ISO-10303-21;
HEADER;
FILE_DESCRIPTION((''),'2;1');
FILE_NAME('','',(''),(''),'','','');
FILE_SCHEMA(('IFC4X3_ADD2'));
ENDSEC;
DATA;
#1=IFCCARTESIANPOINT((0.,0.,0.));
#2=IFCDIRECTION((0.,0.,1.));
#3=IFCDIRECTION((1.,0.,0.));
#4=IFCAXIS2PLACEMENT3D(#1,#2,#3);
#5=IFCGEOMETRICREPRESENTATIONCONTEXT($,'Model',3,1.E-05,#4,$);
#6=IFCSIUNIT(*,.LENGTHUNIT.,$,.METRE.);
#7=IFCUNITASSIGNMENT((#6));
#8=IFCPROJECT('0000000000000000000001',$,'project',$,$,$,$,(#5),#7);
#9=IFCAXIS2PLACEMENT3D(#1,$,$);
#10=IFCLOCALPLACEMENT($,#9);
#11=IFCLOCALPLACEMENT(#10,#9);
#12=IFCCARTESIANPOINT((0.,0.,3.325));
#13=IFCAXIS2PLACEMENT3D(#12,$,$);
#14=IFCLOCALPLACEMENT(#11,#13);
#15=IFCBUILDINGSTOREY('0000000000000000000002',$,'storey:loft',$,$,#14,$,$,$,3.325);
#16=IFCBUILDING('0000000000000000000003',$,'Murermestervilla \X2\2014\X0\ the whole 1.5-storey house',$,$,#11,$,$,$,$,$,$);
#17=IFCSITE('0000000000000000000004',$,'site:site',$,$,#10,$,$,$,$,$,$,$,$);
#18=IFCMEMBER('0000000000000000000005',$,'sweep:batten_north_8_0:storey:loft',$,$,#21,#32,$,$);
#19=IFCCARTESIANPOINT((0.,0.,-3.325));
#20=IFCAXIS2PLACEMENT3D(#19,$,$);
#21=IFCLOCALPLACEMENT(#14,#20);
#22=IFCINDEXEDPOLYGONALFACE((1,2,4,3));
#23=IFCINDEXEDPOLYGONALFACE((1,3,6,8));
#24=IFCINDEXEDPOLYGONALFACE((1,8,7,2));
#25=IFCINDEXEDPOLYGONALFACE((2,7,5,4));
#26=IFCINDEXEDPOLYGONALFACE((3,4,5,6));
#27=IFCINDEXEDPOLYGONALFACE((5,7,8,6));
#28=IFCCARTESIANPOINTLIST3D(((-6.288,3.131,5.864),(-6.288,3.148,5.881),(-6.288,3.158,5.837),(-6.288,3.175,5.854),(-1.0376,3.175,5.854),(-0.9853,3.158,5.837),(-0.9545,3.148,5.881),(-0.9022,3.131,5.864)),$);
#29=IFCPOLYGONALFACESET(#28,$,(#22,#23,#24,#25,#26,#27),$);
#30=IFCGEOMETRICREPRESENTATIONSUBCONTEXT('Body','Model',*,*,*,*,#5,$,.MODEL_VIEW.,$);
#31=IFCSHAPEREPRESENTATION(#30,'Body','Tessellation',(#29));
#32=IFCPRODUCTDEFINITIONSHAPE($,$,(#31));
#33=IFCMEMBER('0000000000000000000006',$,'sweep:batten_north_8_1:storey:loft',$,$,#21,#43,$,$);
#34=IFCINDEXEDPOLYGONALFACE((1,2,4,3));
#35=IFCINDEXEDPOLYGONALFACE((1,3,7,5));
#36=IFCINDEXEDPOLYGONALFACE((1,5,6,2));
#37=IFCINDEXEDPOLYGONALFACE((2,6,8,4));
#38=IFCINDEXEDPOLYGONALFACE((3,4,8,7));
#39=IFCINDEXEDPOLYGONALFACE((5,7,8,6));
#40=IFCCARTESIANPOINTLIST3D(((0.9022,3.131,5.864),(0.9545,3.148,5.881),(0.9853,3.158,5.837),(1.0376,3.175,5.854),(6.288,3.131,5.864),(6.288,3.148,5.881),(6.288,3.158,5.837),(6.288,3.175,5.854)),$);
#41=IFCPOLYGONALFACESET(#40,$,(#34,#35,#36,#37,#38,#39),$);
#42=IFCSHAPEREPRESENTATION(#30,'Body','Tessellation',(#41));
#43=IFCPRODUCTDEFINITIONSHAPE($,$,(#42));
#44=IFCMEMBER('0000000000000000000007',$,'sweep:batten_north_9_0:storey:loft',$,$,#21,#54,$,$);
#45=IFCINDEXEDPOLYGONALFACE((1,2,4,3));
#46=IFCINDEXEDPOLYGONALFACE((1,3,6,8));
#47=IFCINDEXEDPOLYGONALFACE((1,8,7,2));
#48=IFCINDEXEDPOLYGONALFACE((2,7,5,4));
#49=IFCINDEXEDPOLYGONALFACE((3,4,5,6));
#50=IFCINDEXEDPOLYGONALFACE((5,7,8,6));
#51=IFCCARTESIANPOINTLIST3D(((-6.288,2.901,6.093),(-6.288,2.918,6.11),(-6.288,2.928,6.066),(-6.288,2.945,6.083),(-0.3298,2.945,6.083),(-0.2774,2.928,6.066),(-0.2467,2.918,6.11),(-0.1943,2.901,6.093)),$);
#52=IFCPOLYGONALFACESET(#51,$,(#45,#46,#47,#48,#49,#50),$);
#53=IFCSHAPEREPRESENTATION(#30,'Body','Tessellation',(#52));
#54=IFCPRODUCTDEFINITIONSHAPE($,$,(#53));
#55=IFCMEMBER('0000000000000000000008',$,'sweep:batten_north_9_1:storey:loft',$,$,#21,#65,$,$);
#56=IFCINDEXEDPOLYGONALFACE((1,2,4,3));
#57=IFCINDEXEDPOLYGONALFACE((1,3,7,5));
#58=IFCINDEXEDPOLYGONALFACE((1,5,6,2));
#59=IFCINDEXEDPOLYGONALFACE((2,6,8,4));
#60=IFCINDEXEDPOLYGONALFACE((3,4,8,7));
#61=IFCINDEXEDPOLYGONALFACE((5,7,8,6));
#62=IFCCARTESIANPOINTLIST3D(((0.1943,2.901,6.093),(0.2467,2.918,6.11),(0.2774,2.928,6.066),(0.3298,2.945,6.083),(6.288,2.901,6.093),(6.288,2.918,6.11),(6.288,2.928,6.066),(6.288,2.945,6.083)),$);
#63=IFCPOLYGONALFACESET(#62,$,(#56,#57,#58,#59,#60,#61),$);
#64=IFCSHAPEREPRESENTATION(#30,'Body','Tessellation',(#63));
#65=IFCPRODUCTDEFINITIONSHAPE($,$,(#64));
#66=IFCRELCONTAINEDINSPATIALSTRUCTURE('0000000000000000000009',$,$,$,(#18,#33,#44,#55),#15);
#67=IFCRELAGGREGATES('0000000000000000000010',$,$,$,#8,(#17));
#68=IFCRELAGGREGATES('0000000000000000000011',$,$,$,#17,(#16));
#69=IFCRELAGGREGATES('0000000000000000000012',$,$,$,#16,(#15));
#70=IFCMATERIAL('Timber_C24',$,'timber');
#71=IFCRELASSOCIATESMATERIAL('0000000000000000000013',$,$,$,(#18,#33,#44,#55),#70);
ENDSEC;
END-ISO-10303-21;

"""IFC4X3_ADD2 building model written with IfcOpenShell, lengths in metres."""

from ifc_helpers import new_model, si_unit, frame, origin, origin_with_axes, place, context, subcontext, project, spatial, polyline, outline, extrude, clip, halfspace, material, element, save


model = new_model("IFC4X3_ADD2")

# Units and contexts
model_context = context("Model", 3, precision=1e-05, world=origin_with_axes())
body_context = subcontext(model_context, "Body", "Model", "MODEL_VIEW")
ifc_project = project(units=[si_unit("LENGTHUNIT", "METRE")], contexts=[model_context])

# Site, building, storey
placement_1 = place(None, origin())
site = spatial("IfcSite", under=ifc_project, at=placement_1, Name="site:site")
building_placement = place(placement_1, origin())
building = spatial("IfcBuilding", under=site, at=building_placement, Name="Murermestervilla — the whole 1.5-storey house")
storey_placement = place(building_placement, frame((0.0, 0.0, 3.325)))
storey = spatial("IfcBuildingStorey", under=building, at=storey_placement, Name="storey:loft", Elevation=3.325)

# Members
ifc_material_1 = material(Name="Timber_C24", Category="timber")
placement_2 = place(storey_placement, frame((0.0, 0.0, -3.325)))
element("IfcMember", 1, at=placement_2, inside=storey, material=ifc_material_1, Name="sweep:batten_north_8_0:storey:loft", context=body_context, shape_type="CSG", body=[
    clip(extrude(outline(polyline([(0.022, -0.005), (-0.005, 0.022), (-0.022, 0.005), (0.005, -0.022), (0.022, -0.005)])), frame((-6.288, 3.153, 5.859), z_axis=(1.0, 0.0, 0.0), x_axis=(0.0, 1.0, 0.0)), (0.0, 0.0, 1.0), 5.564), halfspace(frame((-1.29, 3.257, 5.596), z_axis=(-0.309017, -0.951057, 0.0), x_axis=(-0.951057, 0.309017, 0.0)), True)),
])
element("IfcMember", 2, at=placement_2, inside=storey, material=ifc_material_1, Name="sweep:batten_north_8_1:storey:loft", context=body_context, shape_type="CSG", body=[
    clip(extrude(outline(polyline([(0.022, -0.005), (-0.005, 0.022), (-0.022, 0.005), (0.005, -0.022), (0.022, -0.005)])), frame((0.724, 3.153, 5.859), z_axis=(1.0, 0.0, 0.0), x_axis=(0.0, 1.0, 0.0)), (0.0, 0.0, 1.0), 5.564), halfspace(frame((1.29, 3.257, 5.596), z_axis=(0.309017, -0.951057, 0.0), x_axis=(-0.951057, -0.309017, 0.0)), True)),
])
element("IfcMember", 3, at=placement_2, inside=storey, material=ifc_material_1, Name="sweep:batten_north_9_0:storey:loft", context=body_context, shape_type="CSG", body=[
    clip(extrude(outline(polyline([(0.022, -0.005), (-0.005, 0.022), (-0.022, 0.005), (0.005, -0.022), (0.022, -0.005)])), frame((-6.288, 2.923, 6.088), z_axis=(1.0, 0.0, 0.0), x_axis=(0.0, 1.0, 0.0)), (0.0, 0.0, 1.0), 6.27), halfspace(frame((-1.29, 3.257, 5.596), z_axis=(-0.309017, -0.951057, 0.0), x_axis=(-0.951057, 0.309017, 0.0)), True)),
])
element("IfcMember", 4, at=placement_2, inside=storey, material=ifc_material_1, Name="sweep:batten_north_9_1:storey:loft", context=body_context, shape_type="CSG", body=[
    clip(extrude(outline(polyline([(0.022, -0.005), (-0.005, 0.022), (-0.022, 0.005), (0.005, -0.022), (0.022, -0.005)])), frame((0.018, 2.923, 6.088), z_axis=(1.0, 0.0, 0.0), x_axis=(0.0, 1.0, 0.0)), (0.0, 0.0, 1.0), 6.27), halfspace(frame((1.29, 3.257, 5.596), z_axis=(0.309017, -0.951057, 0.0), x_axis=(-0.951057, -0.309017, 0.0)), True)),
])

save(model, "model.ifc")
